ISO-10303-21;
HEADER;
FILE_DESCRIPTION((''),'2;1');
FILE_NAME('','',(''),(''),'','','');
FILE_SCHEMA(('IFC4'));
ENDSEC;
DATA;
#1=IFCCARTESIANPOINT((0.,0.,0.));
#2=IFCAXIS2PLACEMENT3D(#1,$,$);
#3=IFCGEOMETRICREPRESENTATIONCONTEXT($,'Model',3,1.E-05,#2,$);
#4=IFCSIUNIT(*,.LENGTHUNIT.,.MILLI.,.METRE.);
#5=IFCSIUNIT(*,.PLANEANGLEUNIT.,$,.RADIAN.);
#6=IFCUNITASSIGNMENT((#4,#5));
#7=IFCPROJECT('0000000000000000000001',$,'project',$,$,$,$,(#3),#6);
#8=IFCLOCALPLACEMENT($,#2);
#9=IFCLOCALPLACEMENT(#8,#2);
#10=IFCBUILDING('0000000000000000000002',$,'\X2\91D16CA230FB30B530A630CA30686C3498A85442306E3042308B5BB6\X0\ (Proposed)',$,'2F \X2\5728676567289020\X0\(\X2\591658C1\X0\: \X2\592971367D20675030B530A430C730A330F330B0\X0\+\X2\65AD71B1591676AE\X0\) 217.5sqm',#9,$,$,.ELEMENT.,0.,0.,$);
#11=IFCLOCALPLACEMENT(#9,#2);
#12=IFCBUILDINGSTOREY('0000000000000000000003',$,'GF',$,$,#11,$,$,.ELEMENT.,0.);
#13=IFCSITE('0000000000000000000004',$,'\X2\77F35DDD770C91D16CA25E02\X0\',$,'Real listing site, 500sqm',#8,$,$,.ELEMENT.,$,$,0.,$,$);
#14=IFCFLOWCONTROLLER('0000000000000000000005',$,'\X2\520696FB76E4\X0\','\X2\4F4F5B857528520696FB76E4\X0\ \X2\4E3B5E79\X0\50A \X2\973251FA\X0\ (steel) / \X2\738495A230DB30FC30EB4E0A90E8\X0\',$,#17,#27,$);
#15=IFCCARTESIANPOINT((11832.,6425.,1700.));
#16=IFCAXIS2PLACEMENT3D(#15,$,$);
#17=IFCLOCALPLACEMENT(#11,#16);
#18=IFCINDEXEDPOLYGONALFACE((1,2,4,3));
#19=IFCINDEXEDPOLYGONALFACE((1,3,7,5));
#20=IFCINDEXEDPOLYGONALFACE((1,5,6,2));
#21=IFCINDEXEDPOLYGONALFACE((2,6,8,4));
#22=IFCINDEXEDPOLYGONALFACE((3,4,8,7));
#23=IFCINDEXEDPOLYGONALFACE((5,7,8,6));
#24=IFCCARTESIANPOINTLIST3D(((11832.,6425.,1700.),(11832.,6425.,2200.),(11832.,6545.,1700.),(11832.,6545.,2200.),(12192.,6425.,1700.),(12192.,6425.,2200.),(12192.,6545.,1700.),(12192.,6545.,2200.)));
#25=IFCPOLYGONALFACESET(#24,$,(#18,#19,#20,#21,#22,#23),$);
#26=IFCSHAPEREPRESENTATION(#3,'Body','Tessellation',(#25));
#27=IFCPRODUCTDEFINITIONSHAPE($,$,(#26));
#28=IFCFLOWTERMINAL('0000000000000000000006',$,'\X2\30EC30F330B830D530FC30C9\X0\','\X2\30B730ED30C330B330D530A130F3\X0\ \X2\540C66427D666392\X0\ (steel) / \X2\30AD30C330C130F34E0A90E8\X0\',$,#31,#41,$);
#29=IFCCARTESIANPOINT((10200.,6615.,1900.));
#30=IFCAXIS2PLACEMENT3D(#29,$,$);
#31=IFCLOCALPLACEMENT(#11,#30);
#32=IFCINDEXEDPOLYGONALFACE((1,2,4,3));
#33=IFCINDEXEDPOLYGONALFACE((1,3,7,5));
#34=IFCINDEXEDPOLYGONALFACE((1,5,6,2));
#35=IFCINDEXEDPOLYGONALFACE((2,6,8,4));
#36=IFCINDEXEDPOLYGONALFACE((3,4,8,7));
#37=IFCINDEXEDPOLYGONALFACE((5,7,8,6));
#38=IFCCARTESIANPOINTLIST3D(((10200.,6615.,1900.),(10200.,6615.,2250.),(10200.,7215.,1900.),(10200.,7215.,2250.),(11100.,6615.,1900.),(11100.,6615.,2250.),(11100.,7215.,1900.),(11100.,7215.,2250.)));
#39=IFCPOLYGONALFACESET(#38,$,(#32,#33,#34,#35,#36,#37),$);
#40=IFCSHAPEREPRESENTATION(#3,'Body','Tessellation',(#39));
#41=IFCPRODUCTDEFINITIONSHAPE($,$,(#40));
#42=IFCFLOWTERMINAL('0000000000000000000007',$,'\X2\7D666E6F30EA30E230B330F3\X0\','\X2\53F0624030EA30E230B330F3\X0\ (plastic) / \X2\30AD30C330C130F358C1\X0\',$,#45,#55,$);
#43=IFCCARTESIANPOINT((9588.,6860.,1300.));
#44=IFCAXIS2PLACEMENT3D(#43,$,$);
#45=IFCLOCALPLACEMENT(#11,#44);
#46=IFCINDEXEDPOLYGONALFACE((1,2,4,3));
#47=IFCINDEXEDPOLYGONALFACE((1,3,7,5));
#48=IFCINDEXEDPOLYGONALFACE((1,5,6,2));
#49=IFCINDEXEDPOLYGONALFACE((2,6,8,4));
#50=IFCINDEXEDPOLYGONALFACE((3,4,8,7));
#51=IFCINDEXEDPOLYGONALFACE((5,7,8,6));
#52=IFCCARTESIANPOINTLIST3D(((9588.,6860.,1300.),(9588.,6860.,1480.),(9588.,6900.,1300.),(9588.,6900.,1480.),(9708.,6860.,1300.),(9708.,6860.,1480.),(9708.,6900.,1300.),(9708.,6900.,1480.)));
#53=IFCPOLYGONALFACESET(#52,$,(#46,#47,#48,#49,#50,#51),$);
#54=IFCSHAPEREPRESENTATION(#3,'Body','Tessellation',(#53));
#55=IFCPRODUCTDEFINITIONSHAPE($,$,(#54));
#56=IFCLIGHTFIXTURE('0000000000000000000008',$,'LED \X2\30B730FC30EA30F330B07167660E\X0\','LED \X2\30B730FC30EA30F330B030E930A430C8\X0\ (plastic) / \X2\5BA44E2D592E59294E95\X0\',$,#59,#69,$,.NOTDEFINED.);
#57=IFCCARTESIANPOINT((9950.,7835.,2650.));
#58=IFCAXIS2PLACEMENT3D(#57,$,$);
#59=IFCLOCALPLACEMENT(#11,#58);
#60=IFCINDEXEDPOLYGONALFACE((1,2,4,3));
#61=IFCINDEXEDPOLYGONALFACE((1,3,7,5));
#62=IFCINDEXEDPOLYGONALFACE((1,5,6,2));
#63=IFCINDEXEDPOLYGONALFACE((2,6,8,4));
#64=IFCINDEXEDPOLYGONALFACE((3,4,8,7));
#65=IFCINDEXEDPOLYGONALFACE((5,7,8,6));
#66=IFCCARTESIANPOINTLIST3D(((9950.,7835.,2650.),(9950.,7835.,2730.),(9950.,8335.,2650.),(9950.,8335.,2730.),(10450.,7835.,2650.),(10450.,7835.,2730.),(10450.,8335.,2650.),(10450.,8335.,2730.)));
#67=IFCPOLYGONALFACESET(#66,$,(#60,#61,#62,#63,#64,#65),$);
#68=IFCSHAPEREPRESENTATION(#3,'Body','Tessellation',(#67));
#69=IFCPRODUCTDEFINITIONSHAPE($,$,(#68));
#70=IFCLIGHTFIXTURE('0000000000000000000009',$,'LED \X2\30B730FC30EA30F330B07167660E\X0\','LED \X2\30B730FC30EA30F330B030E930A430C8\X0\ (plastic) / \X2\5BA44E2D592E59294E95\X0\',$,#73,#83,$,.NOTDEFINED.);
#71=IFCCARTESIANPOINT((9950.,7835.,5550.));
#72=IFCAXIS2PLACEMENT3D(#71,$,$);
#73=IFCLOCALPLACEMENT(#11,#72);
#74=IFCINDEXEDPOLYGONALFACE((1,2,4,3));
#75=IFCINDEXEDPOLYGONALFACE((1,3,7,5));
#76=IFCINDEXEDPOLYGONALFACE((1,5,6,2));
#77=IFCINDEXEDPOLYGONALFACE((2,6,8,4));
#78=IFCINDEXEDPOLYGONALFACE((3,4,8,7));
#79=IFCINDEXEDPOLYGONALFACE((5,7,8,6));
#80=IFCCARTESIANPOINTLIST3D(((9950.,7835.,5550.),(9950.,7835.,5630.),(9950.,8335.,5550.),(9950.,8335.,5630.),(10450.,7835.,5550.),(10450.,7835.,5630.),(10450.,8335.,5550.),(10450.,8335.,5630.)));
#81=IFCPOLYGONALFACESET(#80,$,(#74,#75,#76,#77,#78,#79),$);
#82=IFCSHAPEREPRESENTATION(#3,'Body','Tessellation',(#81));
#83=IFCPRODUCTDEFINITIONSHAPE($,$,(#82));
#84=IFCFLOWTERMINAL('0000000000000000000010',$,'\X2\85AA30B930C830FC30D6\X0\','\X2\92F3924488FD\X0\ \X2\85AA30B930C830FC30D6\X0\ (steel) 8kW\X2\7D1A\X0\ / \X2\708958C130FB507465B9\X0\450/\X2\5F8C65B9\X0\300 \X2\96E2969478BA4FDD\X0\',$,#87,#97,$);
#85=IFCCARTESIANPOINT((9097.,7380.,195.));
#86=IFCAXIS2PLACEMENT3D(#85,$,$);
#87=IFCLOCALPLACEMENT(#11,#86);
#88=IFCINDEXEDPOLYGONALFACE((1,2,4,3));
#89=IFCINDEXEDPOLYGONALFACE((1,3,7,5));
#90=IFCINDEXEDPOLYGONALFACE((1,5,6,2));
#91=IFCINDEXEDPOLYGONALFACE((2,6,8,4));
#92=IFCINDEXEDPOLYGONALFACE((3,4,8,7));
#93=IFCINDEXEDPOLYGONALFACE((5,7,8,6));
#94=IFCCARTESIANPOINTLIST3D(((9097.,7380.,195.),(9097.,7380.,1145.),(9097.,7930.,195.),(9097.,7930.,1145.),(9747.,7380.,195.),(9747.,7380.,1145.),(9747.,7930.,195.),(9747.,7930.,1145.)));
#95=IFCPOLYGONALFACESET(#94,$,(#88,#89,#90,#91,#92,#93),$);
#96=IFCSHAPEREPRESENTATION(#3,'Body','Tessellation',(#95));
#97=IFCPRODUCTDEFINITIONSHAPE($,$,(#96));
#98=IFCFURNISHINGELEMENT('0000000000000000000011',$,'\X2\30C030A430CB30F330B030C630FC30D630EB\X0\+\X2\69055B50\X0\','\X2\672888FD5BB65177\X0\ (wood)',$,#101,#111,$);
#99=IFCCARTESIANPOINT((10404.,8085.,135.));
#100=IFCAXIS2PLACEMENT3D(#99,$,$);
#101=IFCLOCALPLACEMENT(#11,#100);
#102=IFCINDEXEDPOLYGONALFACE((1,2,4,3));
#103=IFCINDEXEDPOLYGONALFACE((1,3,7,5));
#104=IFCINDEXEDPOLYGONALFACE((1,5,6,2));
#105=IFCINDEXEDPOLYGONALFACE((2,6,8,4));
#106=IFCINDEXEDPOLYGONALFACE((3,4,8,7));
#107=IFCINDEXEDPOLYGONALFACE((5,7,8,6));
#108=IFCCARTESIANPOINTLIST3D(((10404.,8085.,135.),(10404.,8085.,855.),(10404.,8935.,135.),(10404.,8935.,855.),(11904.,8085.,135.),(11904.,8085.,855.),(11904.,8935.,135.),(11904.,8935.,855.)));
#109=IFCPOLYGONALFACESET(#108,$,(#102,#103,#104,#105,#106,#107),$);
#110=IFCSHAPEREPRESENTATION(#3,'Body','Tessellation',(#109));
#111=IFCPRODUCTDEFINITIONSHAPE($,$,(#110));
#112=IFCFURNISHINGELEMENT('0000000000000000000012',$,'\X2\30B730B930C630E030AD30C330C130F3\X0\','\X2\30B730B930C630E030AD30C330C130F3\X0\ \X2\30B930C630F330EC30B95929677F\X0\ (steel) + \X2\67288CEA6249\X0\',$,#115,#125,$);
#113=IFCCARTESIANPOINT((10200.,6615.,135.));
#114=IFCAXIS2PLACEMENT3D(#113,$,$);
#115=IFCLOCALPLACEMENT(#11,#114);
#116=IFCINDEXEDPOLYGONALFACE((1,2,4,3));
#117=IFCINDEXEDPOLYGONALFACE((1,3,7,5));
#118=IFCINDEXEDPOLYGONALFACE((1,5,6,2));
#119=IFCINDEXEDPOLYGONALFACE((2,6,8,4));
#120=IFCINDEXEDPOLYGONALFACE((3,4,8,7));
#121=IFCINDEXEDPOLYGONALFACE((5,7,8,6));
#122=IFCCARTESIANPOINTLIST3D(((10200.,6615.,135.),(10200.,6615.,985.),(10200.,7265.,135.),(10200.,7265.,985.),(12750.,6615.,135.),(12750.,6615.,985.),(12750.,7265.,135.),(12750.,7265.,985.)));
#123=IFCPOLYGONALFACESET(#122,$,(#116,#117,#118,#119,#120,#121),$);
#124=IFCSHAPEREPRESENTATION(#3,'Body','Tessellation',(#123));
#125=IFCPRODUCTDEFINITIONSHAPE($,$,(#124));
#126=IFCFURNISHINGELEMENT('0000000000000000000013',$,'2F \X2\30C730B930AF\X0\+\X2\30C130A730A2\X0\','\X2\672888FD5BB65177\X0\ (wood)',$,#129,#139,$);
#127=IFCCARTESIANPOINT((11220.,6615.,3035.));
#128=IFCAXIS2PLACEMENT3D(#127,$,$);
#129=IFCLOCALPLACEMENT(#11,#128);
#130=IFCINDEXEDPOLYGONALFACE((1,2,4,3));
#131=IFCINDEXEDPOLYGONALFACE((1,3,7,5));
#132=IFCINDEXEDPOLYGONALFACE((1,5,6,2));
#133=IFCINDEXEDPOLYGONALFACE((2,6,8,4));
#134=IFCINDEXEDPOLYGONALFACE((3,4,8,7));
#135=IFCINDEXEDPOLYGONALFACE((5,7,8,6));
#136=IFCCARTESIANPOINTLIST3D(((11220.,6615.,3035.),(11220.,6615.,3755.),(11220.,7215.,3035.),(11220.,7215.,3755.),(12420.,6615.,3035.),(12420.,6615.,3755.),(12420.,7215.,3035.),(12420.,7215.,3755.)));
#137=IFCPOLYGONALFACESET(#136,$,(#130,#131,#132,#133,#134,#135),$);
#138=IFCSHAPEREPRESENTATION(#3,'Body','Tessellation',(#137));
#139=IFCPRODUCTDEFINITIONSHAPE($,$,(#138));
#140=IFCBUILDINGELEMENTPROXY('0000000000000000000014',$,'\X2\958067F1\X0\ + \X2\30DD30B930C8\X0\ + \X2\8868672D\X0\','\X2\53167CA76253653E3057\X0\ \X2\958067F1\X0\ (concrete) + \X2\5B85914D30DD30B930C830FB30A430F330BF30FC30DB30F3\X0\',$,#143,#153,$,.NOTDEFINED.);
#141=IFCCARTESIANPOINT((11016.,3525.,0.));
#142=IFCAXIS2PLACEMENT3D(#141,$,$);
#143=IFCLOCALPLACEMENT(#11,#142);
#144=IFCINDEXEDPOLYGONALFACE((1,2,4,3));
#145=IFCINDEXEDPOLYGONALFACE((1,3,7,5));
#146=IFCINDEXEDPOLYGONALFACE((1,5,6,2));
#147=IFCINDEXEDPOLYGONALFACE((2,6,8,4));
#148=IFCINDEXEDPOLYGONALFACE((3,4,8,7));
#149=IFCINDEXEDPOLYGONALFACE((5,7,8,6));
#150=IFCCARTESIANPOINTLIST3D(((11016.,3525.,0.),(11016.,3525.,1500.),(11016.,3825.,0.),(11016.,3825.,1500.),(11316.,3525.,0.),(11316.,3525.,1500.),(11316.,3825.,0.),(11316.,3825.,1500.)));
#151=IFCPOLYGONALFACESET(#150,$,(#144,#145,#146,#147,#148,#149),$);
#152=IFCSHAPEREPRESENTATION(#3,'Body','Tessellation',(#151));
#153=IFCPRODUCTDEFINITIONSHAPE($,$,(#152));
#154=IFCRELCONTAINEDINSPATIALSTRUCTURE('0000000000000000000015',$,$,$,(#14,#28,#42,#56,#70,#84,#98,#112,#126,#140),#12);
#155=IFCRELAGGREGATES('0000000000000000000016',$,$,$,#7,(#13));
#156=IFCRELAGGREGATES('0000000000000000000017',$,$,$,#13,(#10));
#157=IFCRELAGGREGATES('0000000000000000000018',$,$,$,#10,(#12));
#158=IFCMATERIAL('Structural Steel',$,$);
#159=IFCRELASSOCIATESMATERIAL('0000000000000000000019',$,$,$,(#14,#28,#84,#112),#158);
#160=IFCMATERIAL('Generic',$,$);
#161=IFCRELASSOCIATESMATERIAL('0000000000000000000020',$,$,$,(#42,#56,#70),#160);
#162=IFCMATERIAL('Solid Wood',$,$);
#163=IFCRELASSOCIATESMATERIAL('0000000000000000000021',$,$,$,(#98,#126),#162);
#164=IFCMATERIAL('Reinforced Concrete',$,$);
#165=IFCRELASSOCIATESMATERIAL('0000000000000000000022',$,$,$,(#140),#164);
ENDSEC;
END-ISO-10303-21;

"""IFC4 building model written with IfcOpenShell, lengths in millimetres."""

from ifc_helpers import new_model, si_unit, frame, frame_2d, origin, place, context, project, spatial, rectangle, extrude, material, element, save


model = new_model("IFC4")

# Units and contexts
model_context = context("Model", 3, precision=1e-05, world=origin())
ifc_project = project(units=[si_unit("LENGTHUNIT", "METRE", prefix="MILLI"), si_unit("PLANEANGLEUNIT", "RADIAN")], contexts=[model_context])

# Site, building, storey
site_placement = place(None, origin())
site = spatial("IfcSite", under=ifc_project, at=site_placement, Name="石川県金沢市", ObjectType="Real listing site, 500sqm", CompositionType="ELEMENT", RefElevation=0.0)
building_placement = place(site_placement, origin())
building = spatial("IfcBuilding", under=site, at=building_placement, Name="金沢・サウナと水風呂のある家 (Proposed)", ObjectType="2F 在来木造(外壁: 天然素材サイディング+断熱外皮) 217.5sqm", CompositionType="ELEMENT", ElevationOfRefHeight=0.0, ElevationOfTerrain=0.0)
storey_placement = place(building_placement, origin())
storey = spatial("IfcBuildingStorey", under=building, at=storey_placement, Name="GF", CompositionType="ELEMENT", Elevation=0.0)

# Shared definitions
ifc_material_1 = material(Name="Solid Wood")

# Shared definitions
ifc_material_2 = material(Name="Structural Steel")

# Shared definitions
ifc_material_3 = material(Name="Reinforced Concrete")

# Flow controller
flow_controller_placement = place(storey_placement, frame((11832.0, 6425.0, 1700.0)))
element("IfcFlowController", 1, at=flow_controller_placement, inside=storey, material=ifc_material_2, Name="分電盤", Description="住宅用分電盤 主幹50A 露出 (steel) / 玄関ホール上部", context=model_context, shape_type="SweptSolid", body=[
    extrude(rectangle(XDim=360.0, YDim=120.0, at=frame_2d((180.0, 60.0))), frame((11832.0, 6425.0, 1700.0)), (0.0, 0.0, 1.0), 500.0),
])

# Flow terminals
flow_terminal_1_placement = place(storey_placement, frame((10200.0, 6615.0, 1900.0)))
element("IfcFlowTerminal", 2, at=flow_terminal_1_placement, inside=storey, material=ifc_material_2, Name="レンジフード", Description="シロッコファン 同時給排 (steel) / キッチン上部", context=model_context, shape_type="SweptSolid", body=[
    extrude(rectangle(XDim=900.0, YDim=600.0, at=frame_2d((450.0, 300.0))), frame((10200.0, 6615.0, 1900.0)), (0.0, 0.0, 1.0), 350.0),
])
ifc_material_4 = material(Name="Generic")
flow_terminal_2_placement = place(storey_placement, frame((9588.0, 6860.0, 1300.0)))
element("IfcFlowTerminal", 3, at=flow_terminal_2_placement, inside=storey, material=ifc_material_4, Name="給湯リモコン", Description="台所リモコン (plastic) / キッチン壁", context=model_context, shape_type="SweptSolid", body=[
    extrude(rectangle(XDim=120.0, YDim=40.0, at=frame_2d((60.0, 20.0))), frame((9588.0, 6860.0, 1300.0)), (0.0, 0.0, 1.0), 180.0),
])

# Light fixtures
light_fixture_1_placement = place(storey_placement, frame((9950.0, 7835.0, 2650.0)))
element("IfcLightFixture", 4, at=light_fixture_1_placement, inside=storey, material=ifc_material_4, Name="LED シーリング照明", Description="LED シーリングライト (plastic) / 室中央天井", PredefinedType="NOTDEFINED", context=model_context, shape_type="SweptSolid", body=[
    extrude(rectangle(XDim=500.0, YDim=500.0, at=frame_2d((250.0, 250.0))), frame((9950.0, 7835.0, 2650.0)), (0.0, 0.0, 1.0), 80.0),
])
light_fixture_2_placement = place(storey_placement, frame((9950.0, 7835.0, 5550.0)))
element("IfcLightFixture", 5, at=light_fixture_2_placement, inside=storey, material=ifc_material_4, Name="LED シーリング照明", Description="LED シーリングライト (plastic) / 室中央天井", PredefinedType="NOTDEFINED", context=model_context, shape_type="SweptSolid", body=[
    extrude(rectangle(XDim=500.0, YDim=500.0, at=frame_2d((250.0, 250.0))), frame((9950.0, 7835.0, 5550.0)), (0.0, 0.0, 1.0), 80.0),
])

# Flow terminal
flow_terminal_3_placement = place(storey_placement, frame((9097.0, 7380.0, 195.0)))
element("IfcFlowTerminal", 6, at=flow_terminal_3_placement, inside=storey, material=ifc_material_2, Name="薪ストーブ", Description="鋳鉄製 薪ストーブ (steel) 8kW級 / 炉壁・側方450/後方300 離隔確保", context=model_context, shape_type="SweptSolid", body=[
    extrude(rectangle(XDim=650.0, YDim=550.0, at=frame_2d((325.0, 275.0))), frame((9097.0, 7380.0, 195.0)), (0.0, 0.0, 1.0), 950.0),
])

# Furnishing elements
furnishing_1_placement = place(storey_placement, frame((10404.0, 8085.0, 135.0)))
element("IfcFurnishingElement", 7, at=furnishing_1_placement, inside=storey, material=ifc_material_1, Name="ダイニングテーブル+椅子", Description="木製家具 (wood)", context=model_context, shape_type="SweptSolid", body=[
    extrude(rectangle(XDim=1500.0, YDim=850.0, at=frame_2d((750.0, 425.0))), frame((10404.0, 8085.0, 135.0)), (0.0, 0.0, 1.0), 720.0),
])
furnishing_2_placement = place(storey_placement, frame((10200.0, 6615.0, 135.0)))
element("IfcFurnishingElement", 8, at=furnishing_2_placement, inside=storey, material=ifc_material_2, Name="システムキッチン", Description="システムキッチン ステンレス天板 (steel) + 木質扉", context=model_context, shape_type="SweptSolid", body=[
    extrude(rectangle(XDim=2550.0, YDim=650.0, at=frame_2d((1275.0, 325.0))), frame((10200.0, 6615.0, 135.0)), (0.0, 0.0, 1.0), 850.0),
])
furnishing_3_placement = place(storey_placement, frame((11220.0, 6615.0, 3035.0)))
element("IfcFurnishingElement", 9, at=furnishing_3_placement, inside=storey, material=ifc_material_1, Name="2F デスク+チェア", Description="木製家具 (wood)", context=model_context, shape_type="SweptSolid", body=[
    extrude(rectangle(XDim=1200.0, YDim=600.0, at=frame_2d((600.0, 300.0))), frame((11220.0, 6615.0, 3035.0)), (0.0, 0.0, 1.0), 720.0),
])

# Building element proxy
proxy_placement = place(storey_placement, frame((11016.0, 3525.0, 0.0)))
element("IfcBuildingElementProxy", 10, at=proxy_placement, inside=storey, material=ifc_material_3, Name="門柱 + ポスト + 表札", Description="化粧打放し 門柱 (concrete) + 宅配ポスト・インターホン", PredefinedType="NOTDEFINED", context=model_context, shape_type="SweptSolid", body=[
    extrude(rectangle(XDim=300.0, YDim=300.0, at=frame_2d((150.0, 150.0))), frame((11016.0, 3525.0, 0.0)), (0.0, 0.0, 1.0), 1500.0),
])

save(model, "model.ifc")
